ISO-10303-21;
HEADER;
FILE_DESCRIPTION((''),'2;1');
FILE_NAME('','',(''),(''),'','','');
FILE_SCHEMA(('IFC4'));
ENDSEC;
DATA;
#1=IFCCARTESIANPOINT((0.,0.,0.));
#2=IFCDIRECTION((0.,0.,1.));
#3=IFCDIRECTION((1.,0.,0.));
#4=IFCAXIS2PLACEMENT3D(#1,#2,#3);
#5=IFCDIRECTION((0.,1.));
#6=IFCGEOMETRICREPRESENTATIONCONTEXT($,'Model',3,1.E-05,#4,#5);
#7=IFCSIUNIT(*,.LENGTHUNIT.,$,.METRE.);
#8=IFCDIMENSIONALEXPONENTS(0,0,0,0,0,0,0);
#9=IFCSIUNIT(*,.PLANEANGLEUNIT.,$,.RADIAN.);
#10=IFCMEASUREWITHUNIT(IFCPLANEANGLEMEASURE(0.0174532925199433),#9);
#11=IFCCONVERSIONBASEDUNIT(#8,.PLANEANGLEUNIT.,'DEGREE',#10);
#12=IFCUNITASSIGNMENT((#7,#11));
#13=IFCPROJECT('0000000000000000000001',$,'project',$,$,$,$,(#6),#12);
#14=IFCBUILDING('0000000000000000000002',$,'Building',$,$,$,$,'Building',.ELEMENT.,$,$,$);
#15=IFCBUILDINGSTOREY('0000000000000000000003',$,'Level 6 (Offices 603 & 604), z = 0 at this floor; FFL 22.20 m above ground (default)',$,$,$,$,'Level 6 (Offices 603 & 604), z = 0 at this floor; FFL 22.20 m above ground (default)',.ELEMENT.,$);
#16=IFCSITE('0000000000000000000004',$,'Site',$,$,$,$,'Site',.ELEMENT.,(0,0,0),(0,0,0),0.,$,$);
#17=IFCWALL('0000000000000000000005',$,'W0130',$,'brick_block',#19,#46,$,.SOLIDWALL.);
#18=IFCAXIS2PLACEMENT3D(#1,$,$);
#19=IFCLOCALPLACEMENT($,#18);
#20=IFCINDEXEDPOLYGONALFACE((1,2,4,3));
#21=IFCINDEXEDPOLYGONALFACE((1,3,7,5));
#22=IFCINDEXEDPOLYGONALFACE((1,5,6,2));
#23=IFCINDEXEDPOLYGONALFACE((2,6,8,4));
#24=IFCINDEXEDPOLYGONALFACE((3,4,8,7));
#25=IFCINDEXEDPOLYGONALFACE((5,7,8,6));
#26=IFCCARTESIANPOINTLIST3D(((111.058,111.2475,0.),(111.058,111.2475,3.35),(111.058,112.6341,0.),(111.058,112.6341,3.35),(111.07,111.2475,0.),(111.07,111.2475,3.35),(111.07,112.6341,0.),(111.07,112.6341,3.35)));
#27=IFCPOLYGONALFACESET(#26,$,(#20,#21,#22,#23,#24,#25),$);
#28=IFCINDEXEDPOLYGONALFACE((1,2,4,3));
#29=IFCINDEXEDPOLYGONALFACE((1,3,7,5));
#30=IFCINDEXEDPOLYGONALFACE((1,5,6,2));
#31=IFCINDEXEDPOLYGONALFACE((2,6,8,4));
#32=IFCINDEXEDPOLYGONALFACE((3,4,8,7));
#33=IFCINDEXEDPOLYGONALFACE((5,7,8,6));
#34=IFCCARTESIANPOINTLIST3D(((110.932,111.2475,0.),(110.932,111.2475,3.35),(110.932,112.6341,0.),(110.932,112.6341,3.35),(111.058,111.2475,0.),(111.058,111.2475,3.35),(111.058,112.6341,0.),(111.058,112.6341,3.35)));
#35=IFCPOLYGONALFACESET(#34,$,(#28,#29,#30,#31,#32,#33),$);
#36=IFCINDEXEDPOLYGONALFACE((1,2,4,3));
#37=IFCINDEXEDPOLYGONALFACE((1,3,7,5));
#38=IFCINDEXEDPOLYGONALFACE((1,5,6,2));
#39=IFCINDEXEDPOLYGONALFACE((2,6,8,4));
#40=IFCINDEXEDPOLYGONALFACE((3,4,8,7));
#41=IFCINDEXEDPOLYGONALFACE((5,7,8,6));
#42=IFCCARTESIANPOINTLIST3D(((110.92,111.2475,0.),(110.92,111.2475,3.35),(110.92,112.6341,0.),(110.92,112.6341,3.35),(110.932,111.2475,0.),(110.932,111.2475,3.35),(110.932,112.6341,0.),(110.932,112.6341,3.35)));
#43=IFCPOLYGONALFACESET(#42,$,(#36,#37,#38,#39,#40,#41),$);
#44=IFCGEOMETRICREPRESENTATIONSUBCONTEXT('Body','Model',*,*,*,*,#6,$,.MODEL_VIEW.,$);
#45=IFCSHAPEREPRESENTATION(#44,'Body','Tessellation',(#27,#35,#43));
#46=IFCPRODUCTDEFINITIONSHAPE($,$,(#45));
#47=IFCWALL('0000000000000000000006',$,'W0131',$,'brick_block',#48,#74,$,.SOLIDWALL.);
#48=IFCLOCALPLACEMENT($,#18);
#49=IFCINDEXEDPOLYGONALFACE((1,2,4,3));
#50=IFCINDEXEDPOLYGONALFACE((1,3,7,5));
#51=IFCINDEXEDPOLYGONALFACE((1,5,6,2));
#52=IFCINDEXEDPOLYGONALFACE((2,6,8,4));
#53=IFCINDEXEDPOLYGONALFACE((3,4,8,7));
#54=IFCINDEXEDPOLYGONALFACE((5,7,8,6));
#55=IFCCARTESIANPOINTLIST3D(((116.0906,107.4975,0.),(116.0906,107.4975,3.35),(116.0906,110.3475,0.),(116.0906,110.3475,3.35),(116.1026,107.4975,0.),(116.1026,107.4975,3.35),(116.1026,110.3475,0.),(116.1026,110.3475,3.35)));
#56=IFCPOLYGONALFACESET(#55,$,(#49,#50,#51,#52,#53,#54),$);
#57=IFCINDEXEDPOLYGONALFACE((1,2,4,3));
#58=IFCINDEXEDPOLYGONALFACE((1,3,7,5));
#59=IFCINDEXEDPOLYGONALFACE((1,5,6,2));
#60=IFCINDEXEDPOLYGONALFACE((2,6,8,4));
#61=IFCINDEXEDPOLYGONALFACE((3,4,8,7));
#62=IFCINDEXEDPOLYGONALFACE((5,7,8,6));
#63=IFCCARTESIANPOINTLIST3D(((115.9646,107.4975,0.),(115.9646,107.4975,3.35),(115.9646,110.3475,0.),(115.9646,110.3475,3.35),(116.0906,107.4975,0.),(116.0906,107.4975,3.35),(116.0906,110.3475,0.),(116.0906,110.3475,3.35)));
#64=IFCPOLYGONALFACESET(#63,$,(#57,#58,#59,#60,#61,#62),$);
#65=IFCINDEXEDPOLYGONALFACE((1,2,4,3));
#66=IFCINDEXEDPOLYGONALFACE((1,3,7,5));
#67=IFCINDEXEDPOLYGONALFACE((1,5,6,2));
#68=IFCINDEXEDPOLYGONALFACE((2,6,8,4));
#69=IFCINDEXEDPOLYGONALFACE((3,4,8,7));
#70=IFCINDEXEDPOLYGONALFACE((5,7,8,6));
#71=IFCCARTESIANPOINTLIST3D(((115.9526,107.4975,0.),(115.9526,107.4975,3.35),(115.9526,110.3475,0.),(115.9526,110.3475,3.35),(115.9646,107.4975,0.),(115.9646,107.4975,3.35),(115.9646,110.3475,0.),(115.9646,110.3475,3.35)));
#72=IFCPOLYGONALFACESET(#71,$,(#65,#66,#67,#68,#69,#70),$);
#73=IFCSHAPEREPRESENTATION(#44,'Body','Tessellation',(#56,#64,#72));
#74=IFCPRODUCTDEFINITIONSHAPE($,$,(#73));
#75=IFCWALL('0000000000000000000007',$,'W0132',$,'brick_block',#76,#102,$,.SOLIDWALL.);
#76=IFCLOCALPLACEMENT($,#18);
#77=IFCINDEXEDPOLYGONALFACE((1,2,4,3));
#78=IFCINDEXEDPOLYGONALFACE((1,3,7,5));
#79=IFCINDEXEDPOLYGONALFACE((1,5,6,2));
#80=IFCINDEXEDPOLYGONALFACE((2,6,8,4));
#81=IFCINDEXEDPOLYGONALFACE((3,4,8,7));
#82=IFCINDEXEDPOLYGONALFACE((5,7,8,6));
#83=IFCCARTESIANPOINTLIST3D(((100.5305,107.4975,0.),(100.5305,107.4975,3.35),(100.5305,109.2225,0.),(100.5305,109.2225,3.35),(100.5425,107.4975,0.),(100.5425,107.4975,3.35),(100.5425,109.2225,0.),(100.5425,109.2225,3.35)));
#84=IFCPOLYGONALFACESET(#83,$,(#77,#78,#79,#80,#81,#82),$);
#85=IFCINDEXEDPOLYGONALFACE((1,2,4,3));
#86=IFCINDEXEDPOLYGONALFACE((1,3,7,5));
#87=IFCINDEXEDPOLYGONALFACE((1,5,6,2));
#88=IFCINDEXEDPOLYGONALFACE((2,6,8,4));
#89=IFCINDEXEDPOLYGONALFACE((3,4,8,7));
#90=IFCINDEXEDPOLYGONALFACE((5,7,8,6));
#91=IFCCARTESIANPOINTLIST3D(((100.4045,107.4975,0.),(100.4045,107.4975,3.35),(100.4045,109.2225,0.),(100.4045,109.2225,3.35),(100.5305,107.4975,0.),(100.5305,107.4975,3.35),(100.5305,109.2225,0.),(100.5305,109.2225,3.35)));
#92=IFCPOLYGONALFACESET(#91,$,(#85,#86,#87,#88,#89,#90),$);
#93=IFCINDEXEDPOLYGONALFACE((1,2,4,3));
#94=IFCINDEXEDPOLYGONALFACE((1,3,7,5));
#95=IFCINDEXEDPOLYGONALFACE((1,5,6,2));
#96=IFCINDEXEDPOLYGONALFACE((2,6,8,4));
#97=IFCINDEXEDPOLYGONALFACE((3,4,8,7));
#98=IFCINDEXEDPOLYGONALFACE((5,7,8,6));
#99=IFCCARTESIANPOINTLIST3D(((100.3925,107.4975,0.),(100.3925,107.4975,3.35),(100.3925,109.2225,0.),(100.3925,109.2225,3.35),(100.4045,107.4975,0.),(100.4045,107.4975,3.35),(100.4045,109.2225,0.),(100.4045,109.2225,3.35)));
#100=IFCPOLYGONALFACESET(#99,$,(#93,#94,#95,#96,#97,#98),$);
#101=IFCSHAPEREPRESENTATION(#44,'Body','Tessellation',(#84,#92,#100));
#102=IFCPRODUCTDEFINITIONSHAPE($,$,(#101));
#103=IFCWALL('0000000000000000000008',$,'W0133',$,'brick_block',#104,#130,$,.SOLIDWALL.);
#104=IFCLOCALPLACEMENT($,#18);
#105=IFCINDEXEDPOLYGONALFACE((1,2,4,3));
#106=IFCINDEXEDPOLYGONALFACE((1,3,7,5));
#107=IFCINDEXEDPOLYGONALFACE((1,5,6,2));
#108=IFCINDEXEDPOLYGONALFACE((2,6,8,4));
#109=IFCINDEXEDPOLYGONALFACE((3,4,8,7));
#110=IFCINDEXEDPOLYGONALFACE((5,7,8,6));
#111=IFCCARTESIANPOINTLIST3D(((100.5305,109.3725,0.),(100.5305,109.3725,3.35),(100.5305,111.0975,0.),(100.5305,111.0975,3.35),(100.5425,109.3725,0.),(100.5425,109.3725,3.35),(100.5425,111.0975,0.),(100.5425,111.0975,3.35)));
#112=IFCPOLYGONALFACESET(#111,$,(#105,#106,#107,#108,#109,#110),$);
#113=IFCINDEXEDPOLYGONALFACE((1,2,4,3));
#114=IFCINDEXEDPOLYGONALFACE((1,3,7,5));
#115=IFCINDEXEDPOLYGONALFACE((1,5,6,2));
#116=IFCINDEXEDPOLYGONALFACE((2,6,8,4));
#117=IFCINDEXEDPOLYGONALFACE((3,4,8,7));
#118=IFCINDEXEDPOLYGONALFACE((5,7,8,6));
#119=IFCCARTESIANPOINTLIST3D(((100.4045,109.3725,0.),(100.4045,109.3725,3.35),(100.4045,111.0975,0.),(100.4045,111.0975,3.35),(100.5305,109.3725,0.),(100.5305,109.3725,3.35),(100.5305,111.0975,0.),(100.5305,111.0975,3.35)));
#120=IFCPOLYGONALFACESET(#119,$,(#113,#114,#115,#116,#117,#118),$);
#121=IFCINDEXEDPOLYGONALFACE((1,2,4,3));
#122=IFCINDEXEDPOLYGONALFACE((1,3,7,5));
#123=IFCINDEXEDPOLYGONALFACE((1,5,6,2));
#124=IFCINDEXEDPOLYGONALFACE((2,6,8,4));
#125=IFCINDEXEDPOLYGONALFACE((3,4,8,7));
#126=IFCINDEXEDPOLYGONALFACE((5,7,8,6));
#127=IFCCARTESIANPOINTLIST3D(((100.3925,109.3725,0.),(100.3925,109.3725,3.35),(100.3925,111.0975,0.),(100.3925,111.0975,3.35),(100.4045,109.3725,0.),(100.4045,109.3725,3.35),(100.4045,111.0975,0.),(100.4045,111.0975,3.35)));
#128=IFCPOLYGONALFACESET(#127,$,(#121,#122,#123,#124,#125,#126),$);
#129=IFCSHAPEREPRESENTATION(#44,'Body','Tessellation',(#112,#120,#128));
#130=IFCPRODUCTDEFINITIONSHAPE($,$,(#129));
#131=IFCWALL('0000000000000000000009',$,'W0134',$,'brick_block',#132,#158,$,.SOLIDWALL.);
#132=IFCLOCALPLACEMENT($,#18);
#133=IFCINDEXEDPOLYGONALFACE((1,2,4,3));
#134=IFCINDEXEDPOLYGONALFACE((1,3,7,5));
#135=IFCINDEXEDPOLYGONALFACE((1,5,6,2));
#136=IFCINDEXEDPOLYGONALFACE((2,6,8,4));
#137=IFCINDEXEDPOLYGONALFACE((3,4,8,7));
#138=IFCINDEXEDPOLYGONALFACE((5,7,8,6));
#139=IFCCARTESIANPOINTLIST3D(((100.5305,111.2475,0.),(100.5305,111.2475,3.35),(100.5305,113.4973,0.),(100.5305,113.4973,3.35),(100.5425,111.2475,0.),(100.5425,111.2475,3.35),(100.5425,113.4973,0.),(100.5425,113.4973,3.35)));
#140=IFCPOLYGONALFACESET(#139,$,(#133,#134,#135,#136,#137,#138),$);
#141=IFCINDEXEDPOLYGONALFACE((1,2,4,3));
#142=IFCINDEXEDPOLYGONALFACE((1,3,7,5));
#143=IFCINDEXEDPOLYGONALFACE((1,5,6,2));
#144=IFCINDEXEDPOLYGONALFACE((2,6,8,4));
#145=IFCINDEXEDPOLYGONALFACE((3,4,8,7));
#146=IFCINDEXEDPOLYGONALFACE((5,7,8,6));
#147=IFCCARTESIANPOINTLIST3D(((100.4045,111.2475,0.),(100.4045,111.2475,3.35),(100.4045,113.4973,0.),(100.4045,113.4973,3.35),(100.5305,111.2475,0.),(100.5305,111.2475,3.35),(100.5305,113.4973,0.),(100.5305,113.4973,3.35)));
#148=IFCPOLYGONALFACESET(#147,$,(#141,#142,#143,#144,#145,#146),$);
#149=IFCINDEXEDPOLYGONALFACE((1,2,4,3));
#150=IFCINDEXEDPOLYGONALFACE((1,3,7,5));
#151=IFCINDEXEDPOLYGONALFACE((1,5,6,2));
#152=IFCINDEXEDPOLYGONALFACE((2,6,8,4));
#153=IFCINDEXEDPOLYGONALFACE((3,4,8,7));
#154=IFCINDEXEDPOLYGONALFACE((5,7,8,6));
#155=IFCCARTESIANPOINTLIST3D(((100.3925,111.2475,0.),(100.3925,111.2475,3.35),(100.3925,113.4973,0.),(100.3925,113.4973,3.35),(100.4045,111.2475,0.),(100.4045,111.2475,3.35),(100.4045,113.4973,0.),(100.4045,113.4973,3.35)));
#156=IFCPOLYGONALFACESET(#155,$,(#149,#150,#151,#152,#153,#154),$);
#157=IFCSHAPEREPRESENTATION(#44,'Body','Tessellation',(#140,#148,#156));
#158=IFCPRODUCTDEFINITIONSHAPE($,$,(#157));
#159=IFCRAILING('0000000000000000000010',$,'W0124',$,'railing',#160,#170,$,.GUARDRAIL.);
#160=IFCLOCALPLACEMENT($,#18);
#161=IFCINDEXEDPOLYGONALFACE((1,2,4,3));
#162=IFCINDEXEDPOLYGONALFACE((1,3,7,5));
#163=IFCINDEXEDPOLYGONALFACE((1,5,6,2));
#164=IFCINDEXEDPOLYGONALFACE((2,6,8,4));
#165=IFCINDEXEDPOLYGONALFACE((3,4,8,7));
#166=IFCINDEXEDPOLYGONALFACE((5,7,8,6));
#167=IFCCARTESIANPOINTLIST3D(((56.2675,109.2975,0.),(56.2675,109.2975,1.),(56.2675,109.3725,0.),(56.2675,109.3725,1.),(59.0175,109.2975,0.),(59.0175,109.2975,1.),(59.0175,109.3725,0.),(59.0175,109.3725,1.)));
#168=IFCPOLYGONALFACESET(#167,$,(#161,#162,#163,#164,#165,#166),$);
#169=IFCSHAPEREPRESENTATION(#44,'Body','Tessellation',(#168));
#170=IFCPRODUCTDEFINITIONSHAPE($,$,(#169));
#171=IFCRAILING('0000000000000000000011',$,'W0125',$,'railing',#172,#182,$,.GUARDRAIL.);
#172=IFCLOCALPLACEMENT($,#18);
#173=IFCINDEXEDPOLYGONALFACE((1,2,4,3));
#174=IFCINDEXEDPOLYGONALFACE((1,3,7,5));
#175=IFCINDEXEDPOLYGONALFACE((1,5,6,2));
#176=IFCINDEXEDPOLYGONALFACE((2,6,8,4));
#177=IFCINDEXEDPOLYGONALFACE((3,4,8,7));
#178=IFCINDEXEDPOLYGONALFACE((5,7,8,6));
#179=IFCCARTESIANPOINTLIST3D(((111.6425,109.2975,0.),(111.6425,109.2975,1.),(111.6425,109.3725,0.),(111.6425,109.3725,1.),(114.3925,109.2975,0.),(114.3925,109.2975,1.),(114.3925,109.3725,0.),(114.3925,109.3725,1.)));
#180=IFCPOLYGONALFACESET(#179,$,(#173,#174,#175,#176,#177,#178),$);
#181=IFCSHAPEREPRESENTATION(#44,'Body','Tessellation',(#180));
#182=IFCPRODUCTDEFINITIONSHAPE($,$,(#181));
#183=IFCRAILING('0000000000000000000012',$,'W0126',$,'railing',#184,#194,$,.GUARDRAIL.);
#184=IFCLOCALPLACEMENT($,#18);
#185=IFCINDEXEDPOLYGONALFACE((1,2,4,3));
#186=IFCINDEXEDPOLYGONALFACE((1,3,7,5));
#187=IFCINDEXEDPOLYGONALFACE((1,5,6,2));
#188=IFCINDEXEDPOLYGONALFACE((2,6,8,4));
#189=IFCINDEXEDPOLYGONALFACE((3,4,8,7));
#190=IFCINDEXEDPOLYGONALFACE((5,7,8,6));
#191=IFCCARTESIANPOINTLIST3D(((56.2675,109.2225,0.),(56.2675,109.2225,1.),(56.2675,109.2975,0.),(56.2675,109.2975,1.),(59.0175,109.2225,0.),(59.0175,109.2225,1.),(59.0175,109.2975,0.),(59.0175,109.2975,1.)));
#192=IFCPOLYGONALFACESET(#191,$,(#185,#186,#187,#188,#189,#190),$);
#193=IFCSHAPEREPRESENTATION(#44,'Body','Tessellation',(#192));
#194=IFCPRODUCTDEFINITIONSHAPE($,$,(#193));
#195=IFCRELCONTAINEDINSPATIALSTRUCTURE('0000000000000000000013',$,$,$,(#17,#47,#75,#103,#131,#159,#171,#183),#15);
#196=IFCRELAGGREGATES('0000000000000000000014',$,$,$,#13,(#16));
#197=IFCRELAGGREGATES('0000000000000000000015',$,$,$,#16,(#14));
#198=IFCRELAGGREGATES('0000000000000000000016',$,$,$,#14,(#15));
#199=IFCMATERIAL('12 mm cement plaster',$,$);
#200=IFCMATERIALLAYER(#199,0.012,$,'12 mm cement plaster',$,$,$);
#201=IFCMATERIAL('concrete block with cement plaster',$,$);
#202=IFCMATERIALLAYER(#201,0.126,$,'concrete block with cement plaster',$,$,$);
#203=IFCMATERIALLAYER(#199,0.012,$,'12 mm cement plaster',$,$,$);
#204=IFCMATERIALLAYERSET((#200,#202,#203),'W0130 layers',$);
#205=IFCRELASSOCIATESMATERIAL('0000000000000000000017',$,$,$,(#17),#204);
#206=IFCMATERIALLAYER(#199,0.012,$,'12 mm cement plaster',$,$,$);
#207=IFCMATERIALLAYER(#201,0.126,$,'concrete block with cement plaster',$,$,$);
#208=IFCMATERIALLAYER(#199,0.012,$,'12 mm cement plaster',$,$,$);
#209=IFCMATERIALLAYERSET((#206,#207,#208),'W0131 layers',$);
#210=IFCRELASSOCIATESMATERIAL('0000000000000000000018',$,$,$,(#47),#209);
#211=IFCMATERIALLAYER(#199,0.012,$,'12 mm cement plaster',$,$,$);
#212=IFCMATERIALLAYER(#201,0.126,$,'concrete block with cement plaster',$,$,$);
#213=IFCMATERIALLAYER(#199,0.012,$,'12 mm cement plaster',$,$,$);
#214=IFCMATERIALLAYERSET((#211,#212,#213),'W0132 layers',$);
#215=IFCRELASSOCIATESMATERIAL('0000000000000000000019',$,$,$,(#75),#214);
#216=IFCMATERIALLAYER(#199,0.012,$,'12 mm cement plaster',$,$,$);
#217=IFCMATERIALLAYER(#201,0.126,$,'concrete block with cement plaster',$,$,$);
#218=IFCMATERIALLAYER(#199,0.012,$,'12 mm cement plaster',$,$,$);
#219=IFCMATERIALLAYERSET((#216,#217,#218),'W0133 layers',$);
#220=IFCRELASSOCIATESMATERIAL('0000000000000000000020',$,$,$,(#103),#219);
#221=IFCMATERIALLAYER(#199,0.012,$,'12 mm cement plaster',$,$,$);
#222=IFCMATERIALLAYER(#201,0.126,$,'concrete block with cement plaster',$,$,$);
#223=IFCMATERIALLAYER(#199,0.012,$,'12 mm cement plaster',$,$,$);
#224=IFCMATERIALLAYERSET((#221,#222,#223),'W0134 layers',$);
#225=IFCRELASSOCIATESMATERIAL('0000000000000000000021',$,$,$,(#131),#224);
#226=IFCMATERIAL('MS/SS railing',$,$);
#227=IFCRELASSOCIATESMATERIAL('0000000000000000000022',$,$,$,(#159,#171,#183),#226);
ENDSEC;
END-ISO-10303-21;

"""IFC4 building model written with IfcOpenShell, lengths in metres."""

from ifc_helpers import new_model, entity, si_unit, converted_unit, direction, frame, frame_2d, origin_with_axes, place, context, subcontext, project, spatial, rectangle, extrude, material, layer, layer_set, layer_usage, element, save


model = new_model("IFC4")

# Units and contexts
model_context = context("Model", 3, precision=1e-05, world=origin_with_axes(), true_north=direction((0.0, 1.0)))
body_context = subcontext(model_context, "Body", "Model", "MODEL_VIEW")
ifc_project = project(units=[si_unit("LENGTHUNIT", "METRE"), converted_unit("PLANEANGLEUNIT", "DEGREE", entity("IfcPlaneAngleMeasure", 0.0174532925199433), si_unit("PLANEANGLEUNIT", "RADIAN"), dimensions=[0, 0, 0, 0, 0, 0, 0])], contexts=[model_context])

# Site, building, storey
site = spatial("IfcSite", under=ifc_project, Name="Site", LongName="Site", CompositionType="ELEMENT", RefLatitude=(0, 0, 0), RefLongitude=(0, 0, 0), RefElevation=0.0)
building = spatial("IfcBuilding", under=site, Name="Building", LongName="Building", CompositionType="ELEMENT")
storey = spatial("IfcBuildingStorey", under=building, Name="Level 6 (Offices 603 & 604), z = 0 at this floor; FFL 22.20 m above ground (default)", LongName="Level 6 (Offices 603 & 604), z = 0 at this floor; FFL 22.20 m above ground (default)", CompositionType="ELEMENT")

# Walls
ifc_material_1 = material(Name="12 mm cement plaster")
ifc_material_2 = material(Name="concrete block with cement plaster")
placement = place(None, origin_with_axes())
ifc_layer_1 = layer(ifc_material_1, 0.012, Name="12 mm cement plaster")
ifc_layer_2 = layer(ifc_material_2, 0.126, Name="concrete block with cement plaster")
ifc_layer_3 = layer(ifc_material_1, 0.012, Name="12 mm cement plaster")
ifc_layer_set_1 = layer_set([ifc_layer_1, ifc_layer_2, ifc_layer_3], Name="W0130 layers")
ifc_layer_usage_1 = layer_usage(ifc_layer_set_1, "AXIS2", "POSITIVE", -0.075)
element("IfcWall", 1, at=placement, inside=storey, material=ifc_layer_usage_1, Name="W0130", ObjectType="brick_block", PredefinedType="SOLIDWALL", context=body_context, shape_type="SweptSolid", body=[
    extrude(rectangle(XDim=1.3866, YDim=0.012, at=frame_2d((0.0, 0.0), x_axis=(0.0, 1.0))), frame((111.064, 111.9408, 0.0), z_axis=(0.0, 0.0, 1.0), x_axis=(1.0, 0.0, 0.0)), (0.0, 0.0, 1.0), 3.35),
    extrude(rectangle(XDim=1.3866, YDim=0.126, at=frame_2d((-0.069, 0.0), x_axis=(0.0, 1.0))), frame((111.064, 111.9408, 0.0), z_axis=(0.0, 0.0, 1.0), x_axis=(1.0, 0.0, 0.0)), (0.0, 0.0, 1.0), 3.35),
    extrude(rectangle(XDim=1.3866, YDim=0.012, at=frame_2d((-0.138, 0.0), x_axis=(0.0, 1.0))), frame((111.064, 111.9408, 0.0), z_axis=(0.0, 0.0, 1.0), x_axis=(1.0, 0.0, 0.0)), (0.0, 0.0, 1.0), 3.35),
])
ifc_layer_4 = layer(ifc_material_1, 0.012, Name="12 mm cement plaster")
ifc_layer_5 = layer(ifc_material_2, 0.126, Name="concrete block with cement plaster")
ifc_layer_6 = layer(ifc_material_1, 0.012, Name="12 mm cement plaster")
ifc_layer_set_2 = layer_set([ifc_layer_4, ifc_layer_5, ifc_layer_6], Name="W0131 layers")
ifc_layer_usage_2 = layer_usage(ifc_layer_set_2, "AXIS2", "POSITIVE", -0.075)
element("IfcWall", 2, at=placement, inside=storey, material=ifc_layer_usage_2, Name="W0131", ObjectType="brick_block", PredefinedType="SOLIDWALL", context=body_context, shape_type="SweptSolid", body=[
    extrude(rectangle(XDim=2.85, YDim=0.012, at=frame_2d((0.0, 0.0), x_axis=(0.0, 1.0))), frame((116.0966, 108.9225, 0.0), z_axis=(0.0, 0.0, 1.0), x_axis=(1.0, 0.0, 0.0)), (0.0, 0.0, 1.0), 3.35),
    extrude(rectangle(XDim=2.85, YDim=0.126, at=frame_2d((-0.069, 0.0), x_axis=(0.0, 1.0))), frame((116.0966, 108.9225, 0.0), z_axis=(0.0, 0.0, 1.0), x_axis=(1.0, 0.0, 0.0)), (0.0, 0.0, 1.0), 3.35),
    extrude(rectangle(XDim=2.85, YDim=0.012, at=frame_2d((-0.138, 0.0), x_axis=(0.0, 1.0))), frame((116.0966, 108.9225, 0.0), z_axis=(0.0, 0.0, 1.0), x_axis=(1.0, 0.0, 0.0)), (0.0, 0.0, 1.0), 3.35),
])
ifc_layer_7 = layer(ifc_material_1, 0.012, Name="12 mm cement plaster")
ifc_layer_8 = layer(ifc_material_2, 0.126, Name="concrete block with cement plaster")
ifc_layer_9 = layer(ifc_material_1, 0.012, Name="12 mm cement plaster")
ifc_layer_set_3 = layer_set([ifc_layer_7, ifc_layer_8, ifc_layer_9], Name="W0132 layers")
ifc_layer_usage_3 = layer_usage(ifc_layer_set_3, "AXIS2", "POSITIVE", -0.075)
element("IfcWall", 3, at=placement, inside=storey, material=ifc_layer_usage_3, Name="W0132", ObjectType="brick_block", PredefinedType="SOLIDWALL", context=body_context, shape_type="SweptSolid", body=[
    extrude(rectangle(XDim=1.725, YDim=0.012, at=frame_2d((0.0, 0.0), x_axis=(0.0, 1.0))), frame((100.5365, 108.36, 0.0), z_axis=(0.0, 0.0, 1.0), x_axis=(1.0, 0.0, 0.0)), (0.0, 0.0, 1.0), 3.35),
    extrude(rectangle(XDim=1.725, YDim=0.126, at=frame_2d((-0.069, 0.0), x_axis=(0.0, 1.0))), frame((100.5365, 108.36, 0.0), z_axis=(0.0, 0.0, 1.0), x_axis=(1.0, 0.0, 0.0)), (0.0, 0.0, 1.0), 3.35),
    extrude(rectangle(XDim=1.725, YDim=0.012, at=frame_2d((-0.138, 0.0), x_axis=(0.0, 1.0))), frame((100.5365, 108.36, 0.0), z_axis=(0.0, 0.0, 1.0), x_axis=(1.0, 0.0, 0.0)), (0.0, 0.0, 1.0), 3.35),
])
ifc_layer_10 = layer(ifc_material_1, 0.012, Name="12 mm cement plaster")
ifc_layer_11 = layer(ifc_material_2, 0.126, Name="concrete block with cement plaster")
ifc_layer_12 = layer(ifc_material_1, 0.012, Name="12 mm cement plaster")
ifc_layer_set_4 = layer_set([ifc_layer_10, ifc_layer_11, ifc_layer_12], Name="W0133 layers")
ifc_layer_usage_4 = layer_usage(ifc_layer_set_4, "AXIS2", "POSITIVE", -0.075)
element("IfcWall", 4, at=placement, inside=storey, material=ifc_layer_usage_4, Name="W0133", ObjectType="brick_block", PredefinedType="SOLIDWALL", context=body_context, shape_type="SweptSolid", body=[
    extrude(rectangle(XDim=1.725, YDim=0.012, at=frame_2d((0.0, 0.0), x_axis=(0.0, 1.0))), frame((100.5365, 110.235, 0.0), z_axis=(0.0, 0.0, 1.0), x_axis=(1.0, 0.0, 0.0)), (0.0, 0.0, 1.0), 3.35),
    extrude(rectangle(XDim=1.725, YDim=0.126, at=frame_2d((-0.069, 0.0), x_axis=(0.0, 1.0))), frame((100.5365, 110.235, 0.0), z_axis=(0.0, 0.0, 1.0), x_axis=(1.0, 0.0, 0.0)), (0.0, 0.0, 1.0), 3.35),
    extrude(rectangle(XDim=1.725, YDim=0.012, at=frame_2d((-0.138, 0.0), x_axis=(0.0, 1.0))), frame((100.5365, 110.235, 0.0), z_axis=(0.0, 0.0, 1.0), x_axis=(1.0, 0.0, 0.0)), (0.0, 0.0, 1.0), 3.35),
])
ifc_layer_13 = layer(ifc_material_1, 0.012, Name="12 mm cement plaster")
ifc_layer_14 = layer(ifc_material_2, 0.126, Name="concrete block with cement plaster")
ifc_layer_15 = layer(ifc_material_1, 0.012, Name="12 mm cement plaster")
ifc_layer_set_5 = layer_set([ifc_layer_13, ifc_layer_14, ifc_layer_15], Name="W0134 layers")
ifc_layer_usage_5 = layer_usage(ifc_layer_set_5, "AXIS2", "POSITIVE", -0.075)
element("IfcWall", 5, at=placement, inside=storey, material=ifc_layer_usage_5, Name="W0134", ObjectType="brick_block", PredefinedType="SOLIDWALL", context=body_context, shape_type="SweptSolid", body=[
    extrude(rectangle(XDim=2.2498, YDim=0.012, at=frame_2d((0.0, 0.0), x_axis=(0.0, 1.0))), frame((100.5365, 112.3724, 0.0), z_axis=(0.0, 0.0, 1.0), x_axis=(1.0, 0.0, 0.0)), (0.0, 0.0, 1.0), 3.35),
    extrude(rectangle(XDim=2.2498, YDim=0.126, at=frame_2d((-0.069, 0.0), x_axis=(0.0, 1.0))), frame((100.5365, 112.3724, 0.0), z_axis=(0.0, 0.0, 1.0), x_axis=(1.0, 0.0, 0.0)), (0.0, 0.0, 1.0), 3.35),
    extrude(rectangle(XDim=2.2498, YDim=0.012, at=frame_2d((-0.138, 0.0), x_axis=(0.0, 1.0))), frame((100.5365, 112.3724, 0.0), z_axis=(0.0, 0.0, 1.0), x_axis=(1.0, 0.0, 0.0)), (0.0, 0.0, 1.0), 3.35),
])

# Railings
ifc_material_3 = material(Name="MS/SS railing")
element("IfcRailing", 6, at=placement, inside=storey, material=ifc_material_3, Name="W0124", ObjectType="railing", PredefinedType="GUARDRAIL", context=body_context, shape_type="SweptSolid", body=[
    extrude(rectangle(XDim=2.75, YDim=0.075, at=frame_2d((0.0, 0.0), x_axis=(1.0, 0.0))), frame((57.6425, 109.335, 0.0), z_axis=(0.0, 0.0, 1.0), x_axis=(1.0, 0.0, 0.0)), (0.0, 0.0, 1.0), 1.0),
])
element("IfcRailing", 7, at=placement, inside=storey, material=ifc_material_3, Name="W0125", ObjectType="railing", PredefinedType="GUARDRAIL", context=body_context, shape_type="SweptSolid", body=[
    extrude(rectangle(XDim=2.75, YDim=0.075, at=frame_2d((0.0, 0.0), x_axis=(1.0, 0.0))), frame((113.0175, 109.335, 0.0), z_axis=(0.0, 0.0, 1.0), x_axis=(1.0, 0.0, 0.0)), (0.0, 0.0, 1.0), 1.0),
])
element("IfcRailing", 8, at=placement, inside=storey, material=ifc_material_3, Name="W0126", ObjectType="railing", PredefinedType="GUARDRAIL", context=body_context, shape_type="SweptSolid", body=[
    extrude(rectangle(XDim=2.75, YDim=0.075, at=frame_2d((0.0, 0.0), x_axis=(1.0, 0.0))), frame((57.6425, 109.26, 0.0), z_axis=(0.0, 0.0, 1.0), x_axis=(1.0, 0.0, 0.0)), (0.0, 0.0, 1.0), 1.0),
])

save(model, "model.ifc")
